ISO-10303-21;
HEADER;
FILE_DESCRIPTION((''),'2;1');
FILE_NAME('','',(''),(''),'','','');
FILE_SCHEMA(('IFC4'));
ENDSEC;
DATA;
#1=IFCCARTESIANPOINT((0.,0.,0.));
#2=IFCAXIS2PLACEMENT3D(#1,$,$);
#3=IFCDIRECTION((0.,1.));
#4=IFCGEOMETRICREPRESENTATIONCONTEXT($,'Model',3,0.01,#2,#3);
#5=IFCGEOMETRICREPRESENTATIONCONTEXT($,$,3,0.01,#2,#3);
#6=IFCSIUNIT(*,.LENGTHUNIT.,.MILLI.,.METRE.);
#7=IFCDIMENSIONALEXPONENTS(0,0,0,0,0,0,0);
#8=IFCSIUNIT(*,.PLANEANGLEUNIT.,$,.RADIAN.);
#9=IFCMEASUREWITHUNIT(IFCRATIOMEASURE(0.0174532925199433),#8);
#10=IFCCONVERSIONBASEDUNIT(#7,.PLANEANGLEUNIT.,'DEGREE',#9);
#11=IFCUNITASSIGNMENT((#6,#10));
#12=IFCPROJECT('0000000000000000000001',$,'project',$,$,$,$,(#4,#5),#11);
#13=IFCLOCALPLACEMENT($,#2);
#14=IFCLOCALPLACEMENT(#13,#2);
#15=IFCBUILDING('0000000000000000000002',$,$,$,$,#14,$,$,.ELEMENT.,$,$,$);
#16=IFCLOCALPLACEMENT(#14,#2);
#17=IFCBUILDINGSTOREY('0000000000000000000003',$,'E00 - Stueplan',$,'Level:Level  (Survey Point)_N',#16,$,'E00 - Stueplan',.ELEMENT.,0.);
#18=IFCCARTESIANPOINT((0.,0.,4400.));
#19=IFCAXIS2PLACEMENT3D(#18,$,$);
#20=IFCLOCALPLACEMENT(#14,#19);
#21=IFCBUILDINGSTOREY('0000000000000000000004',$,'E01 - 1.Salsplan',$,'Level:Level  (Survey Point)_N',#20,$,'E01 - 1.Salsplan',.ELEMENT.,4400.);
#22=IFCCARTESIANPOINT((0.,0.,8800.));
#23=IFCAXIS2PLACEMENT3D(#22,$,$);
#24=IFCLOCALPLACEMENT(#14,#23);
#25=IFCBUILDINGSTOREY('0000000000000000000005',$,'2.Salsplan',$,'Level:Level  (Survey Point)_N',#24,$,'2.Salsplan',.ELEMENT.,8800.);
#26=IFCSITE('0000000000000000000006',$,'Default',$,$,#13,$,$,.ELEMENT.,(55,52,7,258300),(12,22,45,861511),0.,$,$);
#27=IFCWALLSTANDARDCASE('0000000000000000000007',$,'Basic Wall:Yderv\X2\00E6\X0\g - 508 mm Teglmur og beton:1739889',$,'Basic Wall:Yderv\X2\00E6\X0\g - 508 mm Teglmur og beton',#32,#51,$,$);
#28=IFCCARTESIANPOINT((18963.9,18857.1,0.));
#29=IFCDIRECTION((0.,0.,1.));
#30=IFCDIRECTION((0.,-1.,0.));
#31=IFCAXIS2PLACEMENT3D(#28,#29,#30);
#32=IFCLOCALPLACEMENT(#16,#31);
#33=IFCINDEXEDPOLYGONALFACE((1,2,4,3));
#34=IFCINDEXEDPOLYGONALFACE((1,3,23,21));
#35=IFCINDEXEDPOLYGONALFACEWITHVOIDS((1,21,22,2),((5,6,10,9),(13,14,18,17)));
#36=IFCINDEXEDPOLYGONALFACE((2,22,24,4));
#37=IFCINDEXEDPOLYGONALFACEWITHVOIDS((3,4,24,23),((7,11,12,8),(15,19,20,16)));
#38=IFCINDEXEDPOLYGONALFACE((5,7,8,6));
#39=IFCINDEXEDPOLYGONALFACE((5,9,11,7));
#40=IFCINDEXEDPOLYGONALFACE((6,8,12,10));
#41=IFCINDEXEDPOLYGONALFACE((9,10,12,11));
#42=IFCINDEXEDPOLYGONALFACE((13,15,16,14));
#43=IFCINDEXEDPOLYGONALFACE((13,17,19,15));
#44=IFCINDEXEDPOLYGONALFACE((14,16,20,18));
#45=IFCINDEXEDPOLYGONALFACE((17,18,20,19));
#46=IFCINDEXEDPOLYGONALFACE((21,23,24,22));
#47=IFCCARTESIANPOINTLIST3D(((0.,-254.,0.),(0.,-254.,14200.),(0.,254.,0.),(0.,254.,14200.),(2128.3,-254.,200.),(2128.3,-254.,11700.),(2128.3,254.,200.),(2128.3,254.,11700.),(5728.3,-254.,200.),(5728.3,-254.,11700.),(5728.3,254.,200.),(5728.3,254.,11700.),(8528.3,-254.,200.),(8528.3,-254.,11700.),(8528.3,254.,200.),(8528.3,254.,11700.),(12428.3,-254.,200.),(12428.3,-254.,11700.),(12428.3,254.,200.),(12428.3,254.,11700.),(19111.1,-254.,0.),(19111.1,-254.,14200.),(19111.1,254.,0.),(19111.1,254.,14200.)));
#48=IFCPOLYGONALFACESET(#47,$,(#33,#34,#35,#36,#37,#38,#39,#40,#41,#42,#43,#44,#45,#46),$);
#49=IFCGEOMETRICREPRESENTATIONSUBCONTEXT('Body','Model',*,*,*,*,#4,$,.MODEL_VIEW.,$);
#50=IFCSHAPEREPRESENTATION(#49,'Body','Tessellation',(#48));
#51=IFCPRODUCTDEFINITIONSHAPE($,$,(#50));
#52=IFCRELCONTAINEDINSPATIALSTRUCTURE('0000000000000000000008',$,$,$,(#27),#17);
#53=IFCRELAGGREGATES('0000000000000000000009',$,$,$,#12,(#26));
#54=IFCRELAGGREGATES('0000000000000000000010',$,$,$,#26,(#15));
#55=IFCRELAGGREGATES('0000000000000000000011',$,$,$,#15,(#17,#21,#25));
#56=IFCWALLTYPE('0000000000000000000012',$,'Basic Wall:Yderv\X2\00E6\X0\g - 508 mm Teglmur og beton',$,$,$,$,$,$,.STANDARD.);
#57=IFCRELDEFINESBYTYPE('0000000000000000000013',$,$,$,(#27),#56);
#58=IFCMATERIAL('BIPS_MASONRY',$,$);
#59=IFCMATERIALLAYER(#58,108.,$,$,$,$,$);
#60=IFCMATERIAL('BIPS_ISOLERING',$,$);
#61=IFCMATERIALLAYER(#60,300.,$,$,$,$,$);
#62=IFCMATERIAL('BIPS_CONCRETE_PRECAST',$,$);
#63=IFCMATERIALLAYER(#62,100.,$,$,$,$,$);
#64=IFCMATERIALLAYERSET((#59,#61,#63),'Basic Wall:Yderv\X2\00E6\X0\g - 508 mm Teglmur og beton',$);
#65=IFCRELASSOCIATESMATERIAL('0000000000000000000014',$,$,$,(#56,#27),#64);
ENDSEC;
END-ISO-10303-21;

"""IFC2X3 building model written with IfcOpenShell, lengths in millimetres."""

from ifc_helpers import new_model, entity, si_unit, converted_unit, direction, frame, frame_2d, origin, place, context, subcontext, project, spatial, rectangle, extrude, material, layer, layer_set, layer_usage, type_object, element, save


model = new_model("IFC2X3")

# Units and contexts
model_context = context("Model", 3, precision=0.01, world=origin(), true_north=direction((0.0, 1.0)))
context_of_model = context(None, 3, precision=0.01, world=origin(), true_north=direction((0.0, 1.0)))
body_context = subcontext(model_context, "Body", "Model", "MODEL_VIEW")
ifc_project = project(units=[si_unit("LENGTHUNIT", "METRE", prefix="MILLI"), converted_unit("PLANEANGLEUNIT", "DEGREE", entity("IfcRatioMeasure", 0.0174532925199433), si_unit("PLANEANGLEUNIT", "RADIAN"), dimensions=[0, 0, 0, 0, 0, 0, 0])], contexts=[model_context, context_of_model])

# Site, building, storey
site_placement = place(None, origin())
site = spatial("IfcSite", under=ifc_project, at=site_placement, Name="Default", CompositionType="ELEMENT", RefLatitude=(55, 52, 7, 258300), RefLongitude=(12, 22, 45, 861511), RefElevation=0.0)
building_placement = place(site_placement, origin())
building = spatial("IfcBuilding", under=site, at=building_placement, CompositionType="ELEMENT")
storey_1_placement = place(building_placement, origin())
storey_1 = spatial("IfcBuildingStorey", under=building, at=storey_1_placement, Name="E00 - Stueplan", ObjectType="Level:Level  (Survey Point)_N", LongName="E00 - Stueplan", CompositionType="ELEMENT", Elevation=0.0)

# Wall, openings
ifc_material_1 = material(Name="BIPS_MASONRY")
ifc_layer_1 = layer(ifc_material_1, 108.0)
ifc_material_2 = material(Name="BIPS_ISOLERING")
ifc_layer_2 = layer(ifc_material_2, 300.0)
ifc_material_3 = material(Name="BIPS_CONCRETE_PRECAST")
ifc_layer_3 = layer(ifc_material_3, 100.0)
ifc_layer_set_1 = layer_set([ifc_layer_1, ifc_layer_2, ifc_layer_3], Name="Basic Wall:Ydervæg - 508 mm Teglmur og beton")
wall_type_1 = type_object("IfcWallType", Name="Basic Wall:Ydervæg - 508 mm Teglmur og beton", PredefinedType="STANDARD", material=ifc_layer_set_1)
ifc_layer_usage_1 = layer_usage(ifc_layer_set_1, "AXIS2", "NEGATIVE", 254.0)
wall_1_placement = place(storey_1_placement, frame((18963.9, 18857.1, 0.0), z_axis=(0.0, 0.0, 1.0), x_axis=(0.0, -1.0, 0.0)))
wall_1 = element("IfcWallStandardCase", 1, at=wall_1_placement, inside=storey_1, type_object=wall_type_1, material=ifc_layer_usage_1, Name="Basic Wall:Ydervæg - 508 mm Teglmur og beton:1739889", ObjectType="Basic Wall:Ydervæg - 508 mm Teglmur og beton", context=body_context, shape_type="SweptSolid", body=[
    extrude(rectangle(XDim=19111.1, YDim=508.0, at=frame_2d((9555.6, 0.0), x_axis=(-1.0, 0.0))), origin(), (0.0, 0.0, 1.0), 14200.0),
])
opening_1_placement = place(wall_1_placement, origin())
element("IfcOpeningElement", 2, at=opening_1_placement, cuts=wall_1, ObjectType="Opening", context=body_context, shape_type="SweptSolid", body=[
    extrude(rectangle(XDim=11500.0, YDim=3600.0, at=frame_2d((0.0, 0.0), x_axis=(1.0, 0.0))), frame((3928.3, -406.4, 5950.0), z_axis=(0.0, 1.0, 0.0), x_axis=(0.0, 0.0, 1.0)), (0.0, 0.0, 1.0), 812.8),
])
opening_2_placement = place(wall_1_placement, origin())
element("IfcOpeningElement", 3, at=opening_2_placement, cuts=wall_1, ObjectType="Opening", context=body_context, shape_type="SweptSolid", body=[
    extrude(rectangle(XDim=11500.0, YDim=3900.0, at=frame_2d((0.0, 0.0), x_axis=(1.0, 0.0))), frame((10478.3, -406.4, 5950.0), z_axis=(0.0, 1.0, 0.0), x_axis=(0.0, 0.0, 1.0)), (0.0, 0.0, 1.0), 812.8),
])

# Shared definitions
storey_2_placement = place(building_placement, frame((0.0, 0.0, 4400.0)))
storey_2 = spatial("IfcBuildingStorey", under=building, at=storey_2_placement, Name="E01 - 1.Salsplan", ObjectType="Level:Level  (Survey Point)_N", LongName="E01 - 1.Salsplan", CompositionType="ELEMENT", Elevation=4400.0)

# Shared definitions
storey_3_placement = place(building_placement, frame((0.0, 0.0, 8800.0)))
storey_3 = spatial("IfcBuildingStorey", under=building, at=storey_3_placement, Name="2.Salsplan", ObjectType="Level:Level  (Survey Point)_N", LongName="2.Salsplan", CompositionType="ELEMENT", Elevation=8800.0)

save(model, "model.ifc")
